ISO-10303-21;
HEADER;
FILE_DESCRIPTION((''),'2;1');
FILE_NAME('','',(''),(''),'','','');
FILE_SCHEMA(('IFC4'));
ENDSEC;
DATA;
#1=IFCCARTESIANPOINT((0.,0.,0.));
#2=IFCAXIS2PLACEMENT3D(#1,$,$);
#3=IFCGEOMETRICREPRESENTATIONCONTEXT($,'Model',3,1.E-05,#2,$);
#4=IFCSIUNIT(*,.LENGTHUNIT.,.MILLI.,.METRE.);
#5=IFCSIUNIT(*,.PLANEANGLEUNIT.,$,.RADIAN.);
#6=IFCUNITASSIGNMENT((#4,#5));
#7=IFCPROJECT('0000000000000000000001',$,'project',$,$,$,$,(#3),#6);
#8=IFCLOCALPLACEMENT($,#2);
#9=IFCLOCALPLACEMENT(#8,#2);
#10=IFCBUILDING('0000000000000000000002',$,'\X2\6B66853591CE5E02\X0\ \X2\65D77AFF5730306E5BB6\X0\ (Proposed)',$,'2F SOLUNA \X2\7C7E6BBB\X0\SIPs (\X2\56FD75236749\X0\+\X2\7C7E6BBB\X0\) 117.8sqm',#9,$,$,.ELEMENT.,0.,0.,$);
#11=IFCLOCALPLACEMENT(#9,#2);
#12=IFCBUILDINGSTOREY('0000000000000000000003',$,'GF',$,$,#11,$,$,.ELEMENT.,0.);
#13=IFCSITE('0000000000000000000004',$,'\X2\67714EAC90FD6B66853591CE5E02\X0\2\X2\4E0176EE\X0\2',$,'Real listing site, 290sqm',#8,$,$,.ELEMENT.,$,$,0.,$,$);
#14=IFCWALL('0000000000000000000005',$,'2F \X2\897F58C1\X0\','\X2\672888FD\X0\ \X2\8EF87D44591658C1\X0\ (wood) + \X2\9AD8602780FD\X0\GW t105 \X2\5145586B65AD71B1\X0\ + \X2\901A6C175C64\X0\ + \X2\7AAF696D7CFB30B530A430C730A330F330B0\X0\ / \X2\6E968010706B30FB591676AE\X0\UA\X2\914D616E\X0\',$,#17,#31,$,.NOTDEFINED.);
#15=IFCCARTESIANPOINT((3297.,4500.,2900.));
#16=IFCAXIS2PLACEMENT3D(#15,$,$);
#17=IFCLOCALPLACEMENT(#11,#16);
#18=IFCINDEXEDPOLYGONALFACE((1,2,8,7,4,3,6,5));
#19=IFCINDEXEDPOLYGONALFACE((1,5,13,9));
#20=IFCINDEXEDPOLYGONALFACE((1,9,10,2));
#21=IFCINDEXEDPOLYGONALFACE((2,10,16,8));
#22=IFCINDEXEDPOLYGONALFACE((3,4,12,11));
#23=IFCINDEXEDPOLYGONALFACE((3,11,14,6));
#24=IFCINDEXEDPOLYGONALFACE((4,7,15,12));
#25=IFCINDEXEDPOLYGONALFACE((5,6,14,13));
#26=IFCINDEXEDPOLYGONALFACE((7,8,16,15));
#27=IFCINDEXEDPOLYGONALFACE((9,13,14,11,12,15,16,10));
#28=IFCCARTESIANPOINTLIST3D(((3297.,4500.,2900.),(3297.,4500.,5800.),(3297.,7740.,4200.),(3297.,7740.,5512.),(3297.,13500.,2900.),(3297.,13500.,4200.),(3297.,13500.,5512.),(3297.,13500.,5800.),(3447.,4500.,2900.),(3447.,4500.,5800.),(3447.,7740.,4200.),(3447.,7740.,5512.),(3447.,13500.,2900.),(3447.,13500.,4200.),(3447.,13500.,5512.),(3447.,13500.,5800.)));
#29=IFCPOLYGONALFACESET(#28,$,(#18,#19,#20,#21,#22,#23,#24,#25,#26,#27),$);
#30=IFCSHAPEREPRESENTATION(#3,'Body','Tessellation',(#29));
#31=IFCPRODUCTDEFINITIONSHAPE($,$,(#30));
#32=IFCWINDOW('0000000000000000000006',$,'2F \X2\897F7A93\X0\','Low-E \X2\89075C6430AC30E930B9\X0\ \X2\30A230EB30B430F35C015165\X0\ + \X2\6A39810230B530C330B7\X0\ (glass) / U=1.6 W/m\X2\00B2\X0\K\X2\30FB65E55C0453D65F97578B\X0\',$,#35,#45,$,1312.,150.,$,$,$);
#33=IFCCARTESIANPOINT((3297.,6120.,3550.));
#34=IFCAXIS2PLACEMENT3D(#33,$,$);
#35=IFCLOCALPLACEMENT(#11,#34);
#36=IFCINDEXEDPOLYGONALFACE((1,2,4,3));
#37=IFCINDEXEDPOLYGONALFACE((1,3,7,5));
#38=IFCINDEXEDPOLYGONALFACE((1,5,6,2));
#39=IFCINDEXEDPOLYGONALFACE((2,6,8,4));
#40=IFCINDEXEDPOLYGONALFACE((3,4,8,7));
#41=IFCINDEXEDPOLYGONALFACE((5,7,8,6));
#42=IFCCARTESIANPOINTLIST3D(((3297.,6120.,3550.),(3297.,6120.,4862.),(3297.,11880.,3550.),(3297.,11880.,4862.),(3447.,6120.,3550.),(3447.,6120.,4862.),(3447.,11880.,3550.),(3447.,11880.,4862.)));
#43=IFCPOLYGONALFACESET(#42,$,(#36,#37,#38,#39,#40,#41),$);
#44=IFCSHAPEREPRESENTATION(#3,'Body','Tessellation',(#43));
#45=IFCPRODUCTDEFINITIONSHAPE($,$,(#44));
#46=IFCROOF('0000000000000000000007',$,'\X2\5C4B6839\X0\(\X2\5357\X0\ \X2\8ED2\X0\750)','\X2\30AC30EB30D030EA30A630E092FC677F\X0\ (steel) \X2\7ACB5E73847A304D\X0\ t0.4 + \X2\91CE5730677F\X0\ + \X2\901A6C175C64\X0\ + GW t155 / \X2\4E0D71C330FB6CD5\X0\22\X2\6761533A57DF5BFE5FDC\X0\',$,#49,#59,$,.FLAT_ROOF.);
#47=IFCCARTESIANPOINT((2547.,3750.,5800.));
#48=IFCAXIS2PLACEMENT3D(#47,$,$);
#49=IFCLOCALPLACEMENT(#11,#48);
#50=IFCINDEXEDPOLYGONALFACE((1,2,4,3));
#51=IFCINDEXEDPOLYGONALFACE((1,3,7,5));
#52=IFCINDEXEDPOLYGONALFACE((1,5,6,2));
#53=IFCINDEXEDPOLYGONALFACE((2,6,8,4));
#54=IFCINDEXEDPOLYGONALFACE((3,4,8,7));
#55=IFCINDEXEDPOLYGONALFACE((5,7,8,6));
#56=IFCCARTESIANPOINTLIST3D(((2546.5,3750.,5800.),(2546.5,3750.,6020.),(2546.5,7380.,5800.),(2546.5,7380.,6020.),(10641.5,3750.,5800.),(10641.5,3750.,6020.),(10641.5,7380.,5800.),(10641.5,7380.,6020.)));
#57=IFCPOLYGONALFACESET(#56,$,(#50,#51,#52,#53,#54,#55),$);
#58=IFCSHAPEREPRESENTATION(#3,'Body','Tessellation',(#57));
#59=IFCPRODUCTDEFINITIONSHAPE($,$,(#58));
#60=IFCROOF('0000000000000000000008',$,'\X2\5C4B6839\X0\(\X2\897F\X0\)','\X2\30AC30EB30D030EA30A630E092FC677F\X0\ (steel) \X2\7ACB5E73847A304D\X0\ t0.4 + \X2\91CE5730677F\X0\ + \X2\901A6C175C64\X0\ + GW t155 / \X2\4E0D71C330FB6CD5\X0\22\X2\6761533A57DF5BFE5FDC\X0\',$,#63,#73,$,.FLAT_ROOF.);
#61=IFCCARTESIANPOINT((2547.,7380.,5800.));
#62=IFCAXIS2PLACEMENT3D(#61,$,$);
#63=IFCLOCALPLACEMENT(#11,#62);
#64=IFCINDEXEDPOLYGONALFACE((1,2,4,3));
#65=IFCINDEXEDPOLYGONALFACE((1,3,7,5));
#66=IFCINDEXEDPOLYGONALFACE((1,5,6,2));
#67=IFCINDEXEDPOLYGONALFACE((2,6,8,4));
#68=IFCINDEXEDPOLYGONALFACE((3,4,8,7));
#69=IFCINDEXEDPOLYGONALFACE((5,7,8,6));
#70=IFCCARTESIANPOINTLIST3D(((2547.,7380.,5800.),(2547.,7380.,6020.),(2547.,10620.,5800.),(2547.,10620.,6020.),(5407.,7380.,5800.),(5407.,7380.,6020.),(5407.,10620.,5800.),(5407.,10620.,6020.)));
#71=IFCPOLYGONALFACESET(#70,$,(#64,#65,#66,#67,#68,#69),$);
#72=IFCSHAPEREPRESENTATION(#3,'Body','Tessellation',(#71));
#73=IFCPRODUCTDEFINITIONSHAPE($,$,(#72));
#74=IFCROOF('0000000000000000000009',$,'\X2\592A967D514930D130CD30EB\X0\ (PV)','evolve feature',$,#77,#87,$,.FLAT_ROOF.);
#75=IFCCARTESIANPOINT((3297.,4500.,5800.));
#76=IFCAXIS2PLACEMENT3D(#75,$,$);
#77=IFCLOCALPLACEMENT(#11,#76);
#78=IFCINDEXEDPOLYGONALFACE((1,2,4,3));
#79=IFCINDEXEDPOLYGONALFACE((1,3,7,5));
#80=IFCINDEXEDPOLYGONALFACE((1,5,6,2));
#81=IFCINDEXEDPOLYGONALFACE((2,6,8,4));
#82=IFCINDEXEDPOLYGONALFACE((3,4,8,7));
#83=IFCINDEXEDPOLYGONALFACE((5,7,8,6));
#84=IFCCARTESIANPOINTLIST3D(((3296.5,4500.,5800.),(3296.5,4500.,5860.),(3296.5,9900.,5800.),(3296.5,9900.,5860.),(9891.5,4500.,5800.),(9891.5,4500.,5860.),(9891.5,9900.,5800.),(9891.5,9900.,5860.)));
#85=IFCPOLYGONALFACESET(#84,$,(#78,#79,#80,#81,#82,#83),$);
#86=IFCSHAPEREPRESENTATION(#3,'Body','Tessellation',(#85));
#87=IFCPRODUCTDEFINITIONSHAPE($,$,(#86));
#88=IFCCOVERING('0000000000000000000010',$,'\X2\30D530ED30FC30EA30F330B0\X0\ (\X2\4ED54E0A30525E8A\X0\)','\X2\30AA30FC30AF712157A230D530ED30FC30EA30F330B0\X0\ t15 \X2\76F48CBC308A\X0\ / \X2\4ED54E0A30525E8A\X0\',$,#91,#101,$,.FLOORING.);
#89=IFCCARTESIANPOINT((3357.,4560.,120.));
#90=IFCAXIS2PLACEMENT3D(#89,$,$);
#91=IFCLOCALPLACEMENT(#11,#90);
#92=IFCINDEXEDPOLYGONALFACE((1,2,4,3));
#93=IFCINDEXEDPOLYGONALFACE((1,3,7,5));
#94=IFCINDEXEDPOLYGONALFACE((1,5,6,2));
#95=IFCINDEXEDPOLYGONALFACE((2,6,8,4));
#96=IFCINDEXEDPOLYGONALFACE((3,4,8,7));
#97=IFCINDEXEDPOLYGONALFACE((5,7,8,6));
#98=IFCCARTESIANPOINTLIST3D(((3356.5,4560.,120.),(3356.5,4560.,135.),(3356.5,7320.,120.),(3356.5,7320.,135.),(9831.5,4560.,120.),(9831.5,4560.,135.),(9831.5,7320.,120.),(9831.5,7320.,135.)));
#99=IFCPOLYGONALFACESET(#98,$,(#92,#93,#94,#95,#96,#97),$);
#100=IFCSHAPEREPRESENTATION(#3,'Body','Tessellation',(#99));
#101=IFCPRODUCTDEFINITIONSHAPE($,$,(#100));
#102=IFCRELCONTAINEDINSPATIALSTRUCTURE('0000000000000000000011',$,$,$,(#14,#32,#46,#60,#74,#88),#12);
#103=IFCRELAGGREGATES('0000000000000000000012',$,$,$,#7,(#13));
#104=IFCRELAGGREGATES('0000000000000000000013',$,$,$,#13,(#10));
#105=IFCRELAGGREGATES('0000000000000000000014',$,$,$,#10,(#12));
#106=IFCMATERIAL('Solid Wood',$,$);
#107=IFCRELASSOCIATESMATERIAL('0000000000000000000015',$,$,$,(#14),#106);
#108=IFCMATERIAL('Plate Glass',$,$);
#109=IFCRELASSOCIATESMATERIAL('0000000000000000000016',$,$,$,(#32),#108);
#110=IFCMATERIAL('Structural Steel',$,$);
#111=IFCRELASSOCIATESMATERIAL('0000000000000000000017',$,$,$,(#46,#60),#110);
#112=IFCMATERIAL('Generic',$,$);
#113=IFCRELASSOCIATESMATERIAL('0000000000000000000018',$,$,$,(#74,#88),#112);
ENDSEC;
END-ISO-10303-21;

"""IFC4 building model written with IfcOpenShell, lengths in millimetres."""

from ifc_helpers import new_model, si_unit, frame, frame_2d, origin, place, context, project, spatial, rectangle, extrude, material, element, fill, save


model = new_model("IFC4")

# Units and contexts
model_context = context("Model", 3, precision=1e-05, world=origin())
ifc_project = project(units=[si_unit("LENGTHUNIT", "METRE", prefix="MILLI"), si_unit("PLANEANGLEUNIT", "RADIAN")], contexts=[model_context])

# Site, building, storey
site_placement = place(None, origin())
site = spatial("IfcSite", under=ifc_project, at=site_placement, Name="東京都武蔵野市2丁目2", ObjectType="Real listing site, 290sqm", CompositionType="ELEMENT", RefElevation=0.0)
building_placement = place(site_placement, origin())
building = spatial("IfcBuilding", under=site, at=building_placement, Name="武蔵野市 旗竿地の家 (Proposed)", ObjectType="2F SOLUNA 籾殻SIPs (国産杉+籾殻) 117.8sqm", CompositionType="ELEMENT", ElevationOfRefHeight=0.0, ElevationOfTerrain=0.0)
storey_placement = place(building_placement, origin())
storey = spatial("IfcBuildingStorey", under=building, at=storey_placement, Name="GF", CompositionType="ELEMENT", Elevation=0.0)

# Shared definitions
ifc_material_1 = material(Name="Solid Wood")
ifc_material_2 = material(Name="Generic")

# Shared definitions
ifc_material_3 = material(Name="Plate Glass")

# Wall, opening, window
wall_1_placement = place(storey_placement, frame((3297.0, 4500.0, 2900.0)))
wall_1 = element("IfcWall", 1, at=wall_1_placement, inside=storey, material=ifc_material_1, Name="2F 西壁", Description="木製 軸組外壁 (wood) + 高性能GW t105 充填断熱 + 通気層 + 窯業系サイディング / 準耐火・外皮UA配慮", PredefinedType="NOTDEFINED", context=model_context, shape_type="SweptSolid", body=[
    extrude(rectangle(XDim=150.0, YDim=9000.0, at=frame_2d((75.0, 4500.0))), frame((3297.0, 4500.0, 2900.0)), (0.0, 0.0, 1.0), 2900.0),
])
opening_1_placement = place(storey_placement, frame((3297.0, 6120.0, 3550.0)))
opening_1 = element("IfcOpeningElement", 2, at=opening_1_placement, cuts=wall_1, PredefinedType="NOTDEFINED", context=model_context, shape_type="SweptSolid", body=[
    extrude(rectangle(XDim=150.0, YDim=5760.0, at=frame_2d((75.0, 2880.0))), frame((3297.0, 6120.0, 3550.0)), (0.0, 0.0, 1.0), 1312.0),
])
window_1_placement = place(storey_placement, frame((3297.0, 6120.0, 3550.0)))
window_1 = element("IfcWindow", 3, at=window_1_placement, inside=storey, material=ifc_material_3, Name="2F 西窓", Description="Low-E 複層ガラス アルゴン封入 + 樹脂サッシ (glass) / U=1.6 W/m²K・日射取得型", OverallHeight=1312.0, OverallWidth=150.0, context=model_context, shape_type="SweptSolid", body=[
    extrude(rectangle(XDim=150.0, YDim=5760.0, at=frame_2d((75.0, 2880.0))), frame((3297.0, 6120.0, 3550.0)), (0.0, 0.0, 1.0), 1312.0),
])
fill(opening_1, window_1)

# Roofs
ifc_material_4 = material(Name="Structural Steel")
roof_1_placement = place(storey_placement, frame((2547.0, 3750.0, 5800.0)))
element("IfcRoof", 4, at=roof_1_placement, inside=storey, material=ifc_material_4, Name="屋根(南 軒750)", Description="ガルバリウム鋼板 (steel) 立平葺き t0.4 + 野地板 + 通気層 + GW t155 / 不燃・法22条区域対応", PredefinedType="FLAT_ROOF", context=model_context, shape_type="SweptSolid", body=[
    extrude(rectangle(XDim=8095.0, YDim=3630.0, at=frame_2d((4047.0, 1815.0))), frame((2547.0, 3750.0, 5800.0)), (0.0, 0.0, 1.0), 220.0),
])
roof_2_placement = place(storey_placement, frame((2547.0, 7380.0, 5800.0)))
element("IfcRoof", 5, at=roof_2_placement, inside=storey, material=ifc_material_4, Name="屋根(西)", Description="ガルバリウム鋼板 (steel) 立平葺き t0.4 + 野地板 + 通気層 + GW t155 / 不燃・法22条区域対応", PredefinedType="FLAT_ROOF", context=model_context, shape_type="SweptSolid", body=[
    extrude(rectangle(XDim=2860.0, YDim=3240.0, at=frame_2d((1430.0, 1620.0))), frame((2547.0, 7380.0, 5800.0)), (0.0, 0.0, 1.0), 220.0),
])
roof_3_placement = place(storey_placement, frame((3297.0, 4500.0, 5800.0)))
element("IfcRoof", 6, at=roof_3_placement, inside=storey, material=ifc_material_2, Name="太陽光パネル (PV)", Description="evolve feature", PredefinedType="FLAT_ROOF", context=model_context, shape_type="SweptSolid", body=[
    extrude(rectangle(XDim=6595.0, YDim=5400.0, at=frame_2d((3297.0, 2700.0))), frame((3297.0, 4500.0, 5800.0)), (0.0, 0.0, 1.0), 60.0),
])

# Covering
covering_placement = place(storey_placement, frame((3357.0, 4560.0, 120.0)))
element("IfcCovering", 7, at=covering_placement, inside=storey, material=ifc_material_2, Name="フローリング (仕上げ床)", Description="オーク無垢フローリング t15 直貼り / 仕上げ床", PredefinedType="FLOORING", context=model_context, shape_type="SweptSolid", body=[
    extrude(rectangle(XDim=6475.0, YDim=2760.0, at=frame_2d((3237.0, 1380.0))), frame((3357.0, 4560.0, 120.0)), (0.0, 0.0, 1.0), 15.0),
])

save(model, "model.ifc")
